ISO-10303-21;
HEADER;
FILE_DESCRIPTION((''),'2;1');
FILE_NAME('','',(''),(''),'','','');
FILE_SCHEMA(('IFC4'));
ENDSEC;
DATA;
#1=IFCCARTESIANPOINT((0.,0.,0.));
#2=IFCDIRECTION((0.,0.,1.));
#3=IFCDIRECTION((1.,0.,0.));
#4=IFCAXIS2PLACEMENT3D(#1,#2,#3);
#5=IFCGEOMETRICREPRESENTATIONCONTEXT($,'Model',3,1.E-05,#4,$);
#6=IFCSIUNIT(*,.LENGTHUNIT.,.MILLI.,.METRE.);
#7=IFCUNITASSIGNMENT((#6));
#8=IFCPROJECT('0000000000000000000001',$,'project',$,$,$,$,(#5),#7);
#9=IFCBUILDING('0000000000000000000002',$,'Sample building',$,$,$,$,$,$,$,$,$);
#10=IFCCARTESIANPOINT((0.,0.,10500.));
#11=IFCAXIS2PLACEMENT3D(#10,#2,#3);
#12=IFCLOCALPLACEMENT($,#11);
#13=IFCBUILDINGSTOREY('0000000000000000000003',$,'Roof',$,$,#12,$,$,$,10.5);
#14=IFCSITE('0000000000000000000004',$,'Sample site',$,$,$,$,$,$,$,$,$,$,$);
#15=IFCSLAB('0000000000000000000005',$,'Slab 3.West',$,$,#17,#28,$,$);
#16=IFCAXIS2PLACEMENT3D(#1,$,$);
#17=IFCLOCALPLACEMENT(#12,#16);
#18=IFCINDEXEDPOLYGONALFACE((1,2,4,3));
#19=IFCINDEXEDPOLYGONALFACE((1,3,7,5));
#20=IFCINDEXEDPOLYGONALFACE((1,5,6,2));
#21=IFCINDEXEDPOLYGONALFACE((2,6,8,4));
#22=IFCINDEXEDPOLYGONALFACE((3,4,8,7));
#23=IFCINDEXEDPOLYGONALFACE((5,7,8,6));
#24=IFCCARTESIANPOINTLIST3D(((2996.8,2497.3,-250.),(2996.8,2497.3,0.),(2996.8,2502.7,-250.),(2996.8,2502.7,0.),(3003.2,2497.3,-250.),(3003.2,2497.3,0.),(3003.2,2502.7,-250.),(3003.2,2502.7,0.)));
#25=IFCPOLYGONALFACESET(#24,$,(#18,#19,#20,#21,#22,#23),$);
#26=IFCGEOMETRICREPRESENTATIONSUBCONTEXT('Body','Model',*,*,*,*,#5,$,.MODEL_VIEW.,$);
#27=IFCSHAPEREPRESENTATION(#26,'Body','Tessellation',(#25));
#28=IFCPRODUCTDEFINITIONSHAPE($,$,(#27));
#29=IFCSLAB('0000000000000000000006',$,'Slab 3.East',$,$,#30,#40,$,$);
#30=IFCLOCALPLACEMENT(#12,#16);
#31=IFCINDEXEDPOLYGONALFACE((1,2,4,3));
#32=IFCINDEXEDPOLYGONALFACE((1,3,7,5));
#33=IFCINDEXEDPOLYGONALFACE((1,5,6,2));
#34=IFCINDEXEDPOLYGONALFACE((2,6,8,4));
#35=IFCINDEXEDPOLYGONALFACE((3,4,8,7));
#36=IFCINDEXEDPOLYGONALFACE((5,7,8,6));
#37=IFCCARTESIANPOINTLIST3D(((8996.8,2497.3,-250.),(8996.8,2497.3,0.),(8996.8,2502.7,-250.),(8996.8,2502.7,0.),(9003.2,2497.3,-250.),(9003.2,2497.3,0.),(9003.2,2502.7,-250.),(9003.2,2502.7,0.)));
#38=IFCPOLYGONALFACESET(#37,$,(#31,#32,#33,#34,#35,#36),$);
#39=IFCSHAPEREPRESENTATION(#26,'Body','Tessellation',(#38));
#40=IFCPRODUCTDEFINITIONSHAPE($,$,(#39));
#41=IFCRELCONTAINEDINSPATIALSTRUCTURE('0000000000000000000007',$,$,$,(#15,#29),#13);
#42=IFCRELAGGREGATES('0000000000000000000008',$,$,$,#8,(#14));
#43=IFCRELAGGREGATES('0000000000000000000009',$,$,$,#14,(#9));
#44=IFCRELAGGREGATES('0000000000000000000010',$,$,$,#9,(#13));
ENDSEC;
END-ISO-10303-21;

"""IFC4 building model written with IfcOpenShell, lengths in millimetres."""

from ifc_helpers import new_model, si_unit, frame, origin_with_axes, origin_2d, place, context, subcontext, project, spatial, rectangle, extrude, element, save


model = new_model("IFC4")

# Units and contexts
model_context = context("Model", 3, precision=1e-05, world=origin_with_axes())
body_context = subcontext(model_context, "Body", "Model", "MODEL_VIEW")
ifc_project = project(units=[si_unit("LENGTHUNIT", "METRE", prefix="MILLI")], contexts=[model_context])

# Site, building, storey
site = spatial("IfcSite", under=ifc_project, Name="Sample site")
building = spatial("IfcBuilding", under=site, Name="Sample building")
storey_placement = place(None, frame((0.0, 0.0, 10500.0), z_axis=(0.0, 0.0, 1.0), x_axis=(1.0, 0.0, 0.0)))
storey = spatial("IfcBuildingStorey", under=building, at=storey_placement, Name="Roof", Elevation=10.5)

# Slabs
for number, where, z_axis, x_axis, name in (
    (1, (3000.0, 2500.0, -250.0), (0.0, 0.0, 1.0), (1.0, 0.0, 0.0), "Slab 3.West"),
    (2, (9000.0, 2500.0, -250.0), (0.0, 0.0, 1.0), (1.0, 0.0, 0.0), "Slab 3.East"),
):
    element("IfcSlab", number, at=place(storey_placement, frame(where, z_axis=z_axis, x_axis=x_axis)), inside=storey, Name=name, context=body_context, shape_type="SweptSolid", body=[
        extrude(rectangle(XDim=6.4, YDim=5.4, at=origin_2d()), origin_with_axes(), (0.0, 0.0, 1.0), 250.0),
    ])

save(model, "model.ifc")
